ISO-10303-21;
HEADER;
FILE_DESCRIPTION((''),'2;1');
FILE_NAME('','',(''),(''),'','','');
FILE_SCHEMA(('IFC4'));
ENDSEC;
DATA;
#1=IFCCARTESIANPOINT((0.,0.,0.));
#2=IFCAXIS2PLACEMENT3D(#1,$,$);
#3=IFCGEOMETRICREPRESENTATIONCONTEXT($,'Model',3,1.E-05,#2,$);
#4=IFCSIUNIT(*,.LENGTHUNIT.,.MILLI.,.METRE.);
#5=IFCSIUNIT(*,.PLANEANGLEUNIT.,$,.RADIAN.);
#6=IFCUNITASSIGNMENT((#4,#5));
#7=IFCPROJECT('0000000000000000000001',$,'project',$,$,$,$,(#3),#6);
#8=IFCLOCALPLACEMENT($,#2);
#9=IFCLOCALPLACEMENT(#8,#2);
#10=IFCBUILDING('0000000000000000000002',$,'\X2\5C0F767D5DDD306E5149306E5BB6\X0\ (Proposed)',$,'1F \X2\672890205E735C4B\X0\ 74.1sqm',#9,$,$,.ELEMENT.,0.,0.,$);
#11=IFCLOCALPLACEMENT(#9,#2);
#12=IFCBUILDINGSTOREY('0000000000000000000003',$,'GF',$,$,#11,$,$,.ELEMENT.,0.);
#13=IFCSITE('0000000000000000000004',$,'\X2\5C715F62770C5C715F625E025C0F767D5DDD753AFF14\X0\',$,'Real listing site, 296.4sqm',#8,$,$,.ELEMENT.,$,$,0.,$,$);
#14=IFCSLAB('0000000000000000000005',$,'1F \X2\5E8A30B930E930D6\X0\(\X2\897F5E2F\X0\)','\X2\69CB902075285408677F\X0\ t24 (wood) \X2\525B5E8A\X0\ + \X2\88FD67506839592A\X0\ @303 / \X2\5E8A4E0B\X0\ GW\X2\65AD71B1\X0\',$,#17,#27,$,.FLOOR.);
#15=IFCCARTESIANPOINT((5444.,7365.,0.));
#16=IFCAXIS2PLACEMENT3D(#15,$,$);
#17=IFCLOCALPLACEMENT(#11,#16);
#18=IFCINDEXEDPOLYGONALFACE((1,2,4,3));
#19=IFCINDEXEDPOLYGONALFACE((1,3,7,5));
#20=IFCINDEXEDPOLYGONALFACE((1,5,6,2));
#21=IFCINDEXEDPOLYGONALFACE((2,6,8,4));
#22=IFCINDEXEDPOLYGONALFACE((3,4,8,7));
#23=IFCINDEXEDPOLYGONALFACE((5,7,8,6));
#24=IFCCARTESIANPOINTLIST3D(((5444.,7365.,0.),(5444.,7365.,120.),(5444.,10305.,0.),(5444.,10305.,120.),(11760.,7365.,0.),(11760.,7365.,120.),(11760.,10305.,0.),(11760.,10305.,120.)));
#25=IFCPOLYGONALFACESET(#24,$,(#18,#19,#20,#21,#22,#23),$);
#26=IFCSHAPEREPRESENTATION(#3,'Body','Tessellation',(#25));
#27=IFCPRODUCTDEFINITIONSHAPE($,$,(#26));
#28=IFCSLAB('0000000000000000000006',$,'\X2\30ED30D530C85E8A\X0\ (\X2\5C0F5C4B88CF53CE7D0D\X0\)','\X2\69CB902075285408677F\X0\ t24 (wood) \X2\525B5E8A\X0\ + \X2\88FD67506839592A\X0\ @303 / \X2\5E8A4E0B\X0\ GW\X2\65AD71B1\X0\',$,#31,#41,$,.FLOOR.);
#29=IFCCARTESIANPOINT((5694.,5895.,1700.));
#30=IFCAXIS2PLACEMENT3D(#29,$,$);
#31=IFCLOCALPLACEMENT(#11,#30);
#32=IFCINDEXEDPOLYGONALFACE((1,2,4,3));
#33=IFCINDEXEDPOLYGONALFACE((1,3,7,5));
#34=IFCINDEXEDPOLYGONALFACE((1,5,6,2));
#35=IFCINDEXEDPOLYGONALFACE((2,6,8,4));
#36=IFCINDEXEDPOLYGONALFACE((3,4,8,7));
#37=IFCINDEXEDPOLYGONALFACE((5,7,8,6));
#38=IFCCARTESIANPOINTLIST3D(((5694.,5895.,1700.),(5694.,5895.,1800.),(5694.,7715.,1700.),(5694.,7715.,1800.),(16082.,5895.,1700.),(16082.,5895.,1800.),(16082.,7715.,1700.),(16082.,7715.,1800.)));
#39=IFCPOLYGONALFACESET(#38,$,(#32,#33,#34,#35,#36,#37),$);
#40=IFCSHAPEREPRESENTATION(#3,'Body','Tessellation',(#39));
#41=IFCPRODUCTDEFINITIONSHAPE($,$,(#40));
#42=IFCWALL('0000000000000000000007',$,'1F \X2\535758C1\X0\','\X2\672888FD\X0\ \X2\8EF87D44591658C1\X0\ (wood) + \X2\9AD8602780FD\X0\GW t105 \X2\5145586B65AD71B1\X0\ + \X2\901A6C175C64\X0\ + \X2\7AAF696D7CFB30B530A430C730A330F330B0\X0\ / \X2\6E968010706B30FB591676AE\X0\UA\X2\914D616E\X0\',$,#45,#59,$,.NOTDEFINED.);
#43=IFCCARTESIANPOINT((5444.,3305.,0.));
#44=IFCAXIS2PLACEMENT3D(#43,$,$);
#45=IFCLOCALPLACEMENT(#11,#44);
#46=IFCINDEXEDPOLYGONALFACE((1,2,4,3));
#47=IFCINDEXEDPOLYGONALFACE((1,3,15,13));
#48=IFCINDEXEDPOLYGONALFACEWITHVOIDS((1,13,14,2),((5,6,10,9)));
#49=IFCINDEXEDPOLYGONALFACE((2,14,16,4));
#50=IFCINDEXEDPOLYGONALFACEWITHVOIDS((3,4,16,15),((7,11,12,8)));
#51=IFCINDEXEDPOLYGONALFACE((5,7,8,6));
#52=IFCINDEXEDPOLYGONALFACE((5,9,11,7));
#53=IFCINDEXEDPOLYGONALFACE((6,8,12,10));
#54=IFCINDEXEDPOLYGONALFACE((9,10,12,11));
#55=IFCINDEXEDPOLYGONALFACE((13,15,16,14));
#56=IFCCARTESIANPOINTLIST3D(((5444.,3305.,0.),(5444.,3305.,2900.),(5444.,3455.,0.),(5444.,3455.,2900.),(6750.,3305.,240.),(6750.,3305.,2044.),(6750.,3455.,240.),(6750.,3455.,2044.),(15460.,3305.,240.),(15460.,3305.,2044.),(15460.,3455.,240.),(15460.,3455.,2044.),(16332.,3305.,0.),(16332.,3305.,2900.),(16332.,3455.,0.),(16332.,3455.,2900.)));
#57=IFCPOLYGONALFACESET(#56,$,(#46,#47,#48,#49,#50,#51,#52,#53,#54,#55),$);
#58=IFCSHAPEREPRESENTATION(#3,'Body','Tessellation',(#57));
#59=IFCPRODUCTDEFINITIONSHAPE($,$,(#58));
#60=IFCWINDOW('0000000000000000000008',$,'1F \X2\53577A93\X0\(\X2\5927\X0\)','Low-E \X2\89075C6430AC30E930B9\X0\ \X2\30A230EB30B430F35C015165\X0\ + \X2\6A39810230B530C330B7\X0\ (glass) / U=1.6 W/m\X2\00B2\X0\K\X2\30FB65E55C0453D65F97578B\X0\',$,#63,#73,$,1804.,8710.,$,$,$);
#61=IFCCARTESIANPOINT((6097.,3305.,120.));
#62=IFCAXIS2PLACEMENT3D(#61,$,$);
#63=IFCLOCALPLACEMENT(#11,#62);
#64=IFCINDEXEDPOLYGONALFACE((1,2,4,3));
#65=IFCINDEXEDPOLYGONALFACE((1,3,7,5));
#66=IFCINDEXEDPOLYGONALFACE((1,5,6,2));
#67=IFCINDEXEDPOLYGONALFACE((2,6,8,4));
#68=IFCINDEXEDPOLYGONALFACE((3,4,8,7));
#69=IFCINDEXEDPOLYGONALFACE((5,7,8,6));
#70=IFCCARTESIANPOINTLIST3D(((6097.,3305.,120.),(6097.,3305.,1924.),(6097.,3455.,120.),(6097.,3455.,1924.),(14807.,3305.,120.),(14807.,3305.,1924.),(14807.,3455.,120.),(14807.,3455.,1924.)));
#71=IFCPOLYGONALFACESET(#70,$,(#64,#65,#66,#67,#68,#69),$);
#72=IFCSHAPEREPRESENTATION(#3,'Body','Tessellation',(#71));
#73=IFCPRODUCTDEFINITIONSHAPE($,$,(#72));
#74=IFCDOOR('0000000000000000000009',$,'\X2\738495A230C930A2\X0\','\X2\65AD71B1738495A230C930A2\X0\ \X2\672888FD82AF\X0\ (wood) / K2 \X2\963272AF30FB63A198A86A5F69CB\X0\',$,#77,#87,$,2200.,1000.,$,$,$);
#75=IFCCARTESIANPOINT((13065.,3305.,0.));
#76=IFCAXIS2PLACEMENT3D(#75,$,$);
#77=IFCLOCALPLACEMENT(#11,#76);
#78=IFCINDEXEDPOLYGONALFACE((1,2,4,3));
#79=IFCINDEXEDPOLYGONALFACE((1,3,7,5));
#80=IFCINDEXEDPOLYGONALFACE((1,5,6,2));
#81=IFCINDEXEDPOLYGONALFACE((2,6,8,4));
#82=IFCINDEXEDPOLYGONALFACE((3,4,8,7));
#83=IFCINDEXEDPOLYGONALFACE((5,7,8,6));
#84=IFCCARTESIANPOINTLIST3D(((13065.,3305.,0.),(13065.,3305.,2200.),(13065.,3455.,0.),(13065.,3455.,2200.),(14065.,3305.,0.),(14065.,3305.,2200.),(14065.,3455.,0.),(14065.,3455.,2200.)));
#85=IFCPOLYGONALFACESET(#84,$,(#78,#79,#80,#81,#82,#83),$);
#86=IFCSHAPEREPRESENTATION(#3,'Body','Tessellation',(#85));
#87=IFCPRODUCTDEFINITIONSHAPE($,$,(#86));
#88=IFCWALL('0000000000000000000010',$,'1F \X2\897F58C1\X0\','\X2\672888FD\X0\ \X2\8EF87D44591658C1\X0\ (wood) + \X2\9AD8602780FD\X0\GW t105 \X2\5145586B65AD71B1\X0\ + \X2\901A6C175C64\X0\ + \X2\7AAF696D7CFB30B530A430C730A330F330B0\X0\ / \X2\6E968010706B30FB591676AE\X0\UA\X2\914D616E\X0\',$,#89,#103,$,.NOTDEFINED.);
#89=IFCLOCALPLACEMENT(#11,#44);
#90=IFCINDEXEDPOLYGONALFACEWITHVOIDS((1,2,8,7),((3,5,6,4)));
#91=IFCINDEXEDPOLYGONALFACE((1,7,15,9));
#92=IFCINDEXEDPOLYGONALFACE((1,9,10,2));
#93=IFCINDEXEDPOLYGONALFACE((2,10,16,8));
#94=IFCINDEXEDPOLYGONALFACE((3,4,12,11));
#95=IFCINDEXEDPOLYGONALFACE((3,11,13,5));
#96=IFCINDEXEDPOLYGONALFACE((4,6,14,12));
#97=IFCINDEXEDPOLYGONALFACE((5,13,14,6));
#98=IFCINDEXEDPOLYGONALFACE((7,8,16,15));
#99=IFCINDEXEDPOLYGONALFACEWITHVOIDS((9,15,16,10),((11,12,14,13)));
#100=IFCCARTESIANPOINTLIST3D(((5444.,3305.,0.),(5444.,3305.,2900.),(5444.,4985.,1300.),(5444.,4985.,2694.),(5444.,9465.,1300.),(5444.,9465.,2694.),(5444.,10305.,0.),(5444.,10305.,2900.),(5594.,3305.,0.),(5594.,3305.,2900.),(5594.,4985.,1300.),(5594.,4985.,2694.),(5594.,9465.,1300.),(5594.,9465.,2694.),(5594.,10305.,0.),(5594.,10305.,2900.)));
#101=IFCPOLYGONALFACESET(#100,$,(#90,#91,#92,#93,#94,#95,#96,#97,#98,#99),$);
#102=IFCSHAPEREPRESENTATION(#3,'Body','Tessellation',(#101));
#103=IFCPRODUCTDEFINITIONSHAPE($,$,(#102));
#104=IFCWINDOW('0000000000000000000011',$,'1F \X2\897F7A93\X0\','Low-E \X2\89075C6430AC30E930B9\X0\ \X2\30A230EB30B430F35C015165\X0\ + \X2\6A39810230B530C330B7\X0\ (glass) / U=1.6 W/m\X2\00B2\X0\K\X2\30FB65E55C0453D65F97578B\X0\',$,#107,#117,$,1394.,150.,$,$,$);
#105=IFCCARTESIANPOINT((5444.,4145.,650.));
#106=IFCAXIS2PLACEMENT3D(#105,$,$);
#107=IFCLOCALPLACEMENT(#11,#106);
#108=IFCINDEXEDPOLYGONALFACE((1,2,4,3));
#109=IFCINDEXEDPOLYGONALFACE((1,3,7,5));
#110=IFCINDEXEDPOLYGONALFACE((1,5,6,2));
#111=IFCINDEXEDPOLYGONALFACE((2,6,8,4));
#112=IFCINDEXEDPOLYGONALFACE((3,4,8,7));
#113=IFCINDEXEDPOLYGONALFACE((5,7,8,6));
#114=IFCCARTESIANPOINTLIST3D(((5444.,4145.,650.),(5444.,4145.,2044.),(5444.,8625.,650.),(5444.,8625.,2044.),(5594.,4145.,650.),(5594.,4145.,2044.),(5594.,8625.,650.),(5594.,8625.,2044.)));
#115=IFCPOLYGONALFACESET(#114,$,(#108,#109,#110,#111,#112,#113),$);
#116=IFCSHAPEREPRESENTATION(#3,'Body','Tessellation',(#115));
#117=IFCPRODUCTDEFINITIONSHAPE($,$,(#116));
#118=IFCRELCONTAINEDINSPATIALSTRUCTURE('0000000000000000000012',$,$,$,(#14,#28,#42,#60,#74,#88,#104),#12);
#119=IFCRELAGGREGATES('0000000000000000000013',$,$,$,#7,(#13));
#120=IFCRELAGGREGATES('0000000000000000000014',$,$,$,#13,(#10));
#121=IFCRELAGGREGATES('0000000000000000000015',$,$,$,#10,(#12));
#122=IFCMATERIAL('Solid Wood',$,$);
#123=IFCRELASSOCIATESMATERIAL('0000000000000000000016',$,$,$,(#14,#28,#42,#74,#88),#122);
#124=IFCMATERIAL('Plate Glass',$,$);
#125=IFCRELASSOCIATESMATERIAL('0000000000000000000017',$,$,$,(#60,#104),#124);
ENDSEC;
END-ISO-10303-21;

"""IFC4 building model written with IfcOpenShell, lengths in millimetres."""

from ifc_helpers import new_model, si_unit, frame, frame_2d, origin, place, context, project, spatial, rectangle, extrude, material, element, fill, save


model = new_model("IFC4")

# Units and contexts
model_context = context("Model", 3, precision=1e-05, world=origin())
ifc_project = project(units=[si_unit("LENGTHUNIT", "METRE", prefix="MILLI"), si_unit("PLANEANGLEUNIT", "RADIAN")], contexts=[model_context])

# Site, building, storey
site_placement = place(None, origin())
site = spatial("IfcSite", under=ifc_project, at=site_placement, Name="山形県山形市小白川町４", ObjectType="Real listing site, 296.4sqm", CompositionType="ELEMENT", RefElevation=0.0)
building_placement = place(site_placement, origin())
building = spatial("IfcBuilding", under=site, at=building_placement, Name="小白川の光の家 (Proposed)", ObjectType="1F 木造平屋 74.1sqm", CompositionType="ELEMENT", ElevationOfRefHeight=0.0, ElevationOfTerrain=0.0)
storey_placement = place(building_placement, origin())
storey = spatial("IfcBuildingStorey", under=building, at=storey_placement, Name="GF", CompositionType="ELEMENT", Elevation=0.0)

# Slabs
ifc_material_1 = material(Name="Solid Wood")
slab_1_placement = place(storey_placement, frame((5444.0, 7365.0, 0.0)))
element("IfcSlab", 1, at=slab_1_placement, inside=storey, material=ifc_material_1, Name="1F 床スラブ(西帯)", Description="構造用合板 t24 (wood) 剛床 + 製材根太 @303 / 床下 GW断熱", PredefinedType="FLOOR", context=model_context, shape_type="SweptSolid", body=[
    extrude(rectangle(XDim=6316.0, YDim=2940.0, at=frame_2d((3158.0, 1470.0))), frame((5444.0, 7365.0, 0.0)), (0.0, 0.0, 1.0), 120.0),
])
slab_2_placement = place(storey_placement, frame((5694.0, 5895.0, 1700.0)))
element("IfcSlab", 2, at=slab_2_placement, inside=storey, material=ifc_material_1, Name="ロフト床 (小屋裏収納)", Description="構造用合板 t24 (wood) 剛床 + 製材根太 @303 / 床下 GW断熱", PredefinedType="FLOOR", context=model_context, shape_type="SweptSolid", body=[
    extrude(rectangle(XDim=10388.0, YDim=1820.0, at=frame_2d((5194.0, 910.0))), frame((5694.0, 5895.0, 1700.0)), (0.0, 0.0, 1.0), 100.0),
])

# Wall, openings, window, door
wall_1_placement = place(storey_placement, frame((5444.0, 3305.0, 0.0)))
wall_1 = element("IfcWall", 3, at=wall_1_placement, inside=storey, material=ifc_material_1, Name="1F 南壁", Description="木製 軸組外壁 (wood) + 高性能GW t105 充填断熱 + 通気層 + 窯業系サイディング / 準耐火・外皮UA配慮", PredefinedType="NOTDEFINED", context=model_context, shape_type="SweptSolid", body=[
    extrude(rectangle(XDim=10888.0, YDim=150.0, at=frame_2d((5444.0, 75.0))), frame((5444.0, 3305.0, 0.0)), (0.0, 0.0, 1.0), 2900.0),
])
opening_1_placement = place(storey_placement, frame((6097.0, 3305.0, 120.0)))
opening_1 = element("IfcOpeningElement", 4, at=opening_1_placement, cuts=wall_1, PredefinedType="NOTDEFINED", context=model_context, shape_type="SweptSolid", body=[
    extrude(rectangle(XDim=8710.0, YDim=150.0, at=frame_2d((4355.0, 75.0))), frame((6097.0, 3305.0, 120.0)), (0.0, 0.0, 1.0), 1804.0),
])
opening_2_placement = place(storey_placement, frame((13065.0, 3305.0, 0.0)))
opening_2 = element("IfcOpeningElement", 5, at=opening_2_placement, cuts=wall_1, PredefinedType="NOTDEFINED", context=model_context, shape_type="SweptSolid", body=[
    extrude(rectangle(XDim=1000.0, YDim=150.0, at=frame_2d((500.0, 75.0))), frame((13065.0, 3305.0, 0.0)), (0.0, 0.0, 1.0), 2200.0),
])
ifc_material_2 = material(Name="Plate Glass")
window_1_placement = place(storey_placement, frame((6097.0, 3305.0, 120.0)))
window_1 = element("IfcWindow", 6, at=window_1_placement, inside=storey, material=ifc_material_2, Name="1F 南窓(大)", Description="Low-E 複層ガラス アルゴン封入 + 樹脂サッシ (glass) / U=1.6 W/m²K・日射取得型", OverallHeight=1804.0, OverallWidth=8710.0, context=model_context, shape_type="SweptSolid", body=[
    extrude(rectangle(XDim=8710.0, YDim=150.0, at=frame_2d((4355.0, 75.0))), frame((6097.0, 3305.0, 120.0)), (0.0, 0.0, 1.0), 1804.0),
])
fill(opening_1, window_1)
door_1_placement = place(storey_placement, frame((13065.0, 3305.0, 0.0)))
door_1 = element("IfcDoor", 7, at=door_1_placement, inside=storey, material=ifc_material_1, Name="玄関ドア", Description="断熱玄関ドア 木製芯 (wood) / K2 防犯・採風機構", OverallHeight=2200.0, OverallWidth=1000.0, context=model_context, shape_type="SweptSolid", body=[
    extrude(rectangle(XDim=1000.0, YDim=150.0, at=frame_2d((500.0, 75.0))), frame((13065.0, 3305.0, 0.0)), (0.0, 0.0, 1.0), 2200.0),
])
fill(opening_2, door_1)

# Wall, opening, window
wall_2_placement = place(storey_placement, frame((5444.0, 3305.0, 0.0)))
wall_2 = element("IfcWall", 8, at=wall_2_placement, inside=storey, material=ifc_material_1, Name="1F 西壁", Description="木製 軸組外壁 (wood) + 高性能GW t105 充填断熱 + 通気層 + 窯業系サイディング / 準耐火・外皮UA配慮", PredefinedType="NOTDEFINED", context=model_context, shape_type="SweptSolid", body=[
    extrude(rectangle(XDim=150.0, YDim=7000.0, at=frame_2d((75.0, 3500.0))), frame((5444.0, 3305.0, 0.0)), (0.0, 0.0, 1.0), 2900.0),
])
opening_3_placement = place(storey_placement, frame((5444.0, 4145.0, 650.0)))
opening_3 = element("IfcOpeningElement", 9, at=opening_3_placement, cuts=wall_2, PredefinedType="NOTDEFINED", context=model_context, shape_type="SweptSolid", body=[
    extrude(rectangle(XDim=150.0, YDim=4480.0, at=frame_2d((75.0, 2240.0))), frame((5444.0, 4145.0, 650.0)), (0.0, 0.0, 1.0), 1394.0),
])
window_2_placement = place(storey_placement, frame((5444.0, 4145.0, 650.0)))
window_2 = element("IfcWindow", 10, at=window_2_placement, inside=storey, material=ifc_material_2, Name="1F 西窓", Description="Low-E 複層ガラス アルゴン封入 + 樹脂サッシ (glass) / U=1.6 W/m²K・日射取得型", OverallHeight=1394.0, OverallWidth=150.0, context=model_context, shape_type="SweptSolid", body=[
    extrude(rectangle(XDim=150.0, YDim=4480.0, at=frame_2d((75.0, 2240.0))), frame((5444.0, 4145.0, 650.0)), (0.0, 0.0, 1.0), 1394.0),
])
fill(opening_3, window_2)

save(model, "model.ifc")
